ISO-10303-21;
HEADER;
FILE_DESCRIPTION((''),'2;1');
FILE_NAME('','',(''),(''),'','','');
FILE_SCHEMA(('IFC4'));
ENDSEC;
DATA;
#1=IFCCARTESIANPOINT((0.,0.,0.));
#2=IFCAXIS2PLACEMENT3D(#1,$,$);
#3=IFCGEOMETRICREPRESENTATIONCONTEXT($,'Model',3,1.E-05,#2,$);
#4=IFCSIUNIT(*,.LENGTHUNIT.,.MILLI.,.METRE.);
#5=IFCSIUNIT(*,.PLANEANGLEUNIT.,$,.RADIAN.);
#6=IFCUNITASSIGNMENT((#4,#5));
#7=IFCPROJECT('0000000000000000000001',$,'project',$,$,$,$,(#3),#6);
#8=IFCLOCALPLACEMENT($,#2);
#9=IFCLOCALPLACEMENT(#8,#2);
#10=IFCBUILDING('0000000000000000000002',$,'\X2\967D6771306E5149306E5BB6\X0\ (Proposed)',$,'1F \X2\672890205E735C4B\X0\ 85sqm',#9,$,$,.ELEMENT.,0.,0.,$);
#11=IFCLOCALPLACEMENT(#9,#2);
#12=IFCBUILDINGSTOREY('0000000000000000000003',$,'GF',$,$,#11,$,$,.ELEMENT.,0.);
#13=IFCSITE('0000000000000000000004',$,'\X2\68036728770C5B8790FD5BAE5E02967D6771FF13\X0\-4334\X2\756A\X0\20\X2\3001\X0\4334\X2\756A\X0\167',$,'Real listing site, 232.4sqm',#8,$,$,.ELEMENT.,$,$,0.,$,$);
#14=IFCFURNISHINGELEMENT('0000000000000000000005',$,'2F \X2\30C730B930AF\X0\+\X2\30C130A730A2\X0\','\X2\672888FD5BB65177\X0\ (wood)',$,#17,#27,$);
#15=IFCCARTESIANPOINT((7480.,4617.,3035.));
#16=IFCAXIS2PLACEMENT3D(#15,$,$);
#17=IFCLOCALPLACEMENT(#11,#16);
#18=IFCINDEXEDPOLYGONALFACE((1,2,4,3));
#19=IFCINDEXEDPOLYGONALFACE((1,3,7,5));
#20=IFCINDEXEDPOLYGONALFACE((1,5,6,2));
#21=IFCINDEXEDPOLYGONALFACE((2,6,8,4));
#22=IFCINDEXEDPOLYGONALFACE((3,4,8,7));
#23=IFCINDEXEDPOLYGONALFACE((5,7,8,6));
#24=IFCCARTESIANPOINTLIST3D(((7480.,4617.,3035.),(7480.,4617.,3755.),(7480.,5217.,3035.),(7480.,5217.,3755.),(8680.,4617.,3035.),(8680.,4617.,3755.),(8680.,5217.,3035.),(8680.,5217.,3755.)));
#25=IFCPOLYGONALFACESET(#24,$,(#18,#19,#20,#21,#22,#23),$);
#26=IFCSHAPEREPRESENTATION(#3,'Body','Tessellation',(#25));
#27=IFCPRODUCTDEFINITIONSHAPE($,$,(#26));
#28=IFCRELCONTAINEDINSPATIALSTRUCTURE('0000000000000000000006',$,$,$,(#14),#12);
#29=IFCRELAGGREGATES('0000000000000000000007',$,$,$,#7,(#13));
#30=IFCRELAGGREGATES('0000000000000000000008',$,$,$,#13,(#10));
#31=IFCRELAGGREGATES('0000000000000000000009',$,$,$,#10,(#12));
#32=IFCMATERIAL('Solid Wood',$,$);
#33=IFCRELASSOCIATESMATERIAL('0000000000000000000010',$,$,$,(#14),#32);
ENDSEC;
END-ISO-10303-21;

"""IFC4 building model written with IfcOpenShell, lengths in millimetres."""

from ifc_helpers import new_model, si_unit, frame, frame_2d, origin, place, context, project, spatial, rectangle, extrude, material, element, save


model = new_model("IFC4")

# Units and contexts
model_context = context("Model", 3, precision=1e-05, world=origin())
ifc_project = project(units=[si_unit("LENGTHUNIT", "METRE", prefix="MILLI"), si_unit("PLANEANGLEUNIT", "RADIAN")], contexts=[model_context])

# Site, building, storey
site_placement = place(None, origin())
site = spatial("IfcSite", under=ifc_project, at=site_placement, Name="栃木県宇都宮市陽東３-4334番20、4334番167", ObjectType="Real listing site, 232.4sqm", CompositionType="ELEMENT", RefElevation=0.0)
building_placement = place(site_placement, origin())
building = spatial("IfcBuilding", under=site, at=building_placement, Name="陽東の光の家 (Proposed)", ObjectType="1F 木造平屋 85sqm", CompositionType="ELEMENT", ElevationOfRefHeight=0.0, ElevationOfTerrain=0.0)
storey_placement = place(building_placement, origin())
storey = spatial("IfcBuildingStorey", under=building, at=storey_placement, Name="GF", CompositionType="ELEMENT", Elevation=0.0)

# Shared definitions
ifc_material_1 = material(Name="Solid Wood")

# Furnishing element
furnishing_1_placement = place(storey_placement, frame((7480.0, 4617.0, 3035.0)))
element("IfcFurnishingElement", 1, at=furnishing_1_placement, inside=storey, material=ifc_material_1, Name="2F デスク+チェア", Description="木製家具 (wood)", context=model_context, shape_type="SweptSolid", body=[
    extrude(rectangle(XDim=1200.0, YDim=600.0, at=frame_2d((600.0, 300.0))), frame((7480.0, 4617.0, 3035.0)), (0.0, 0.0, 1.0), 720.0),
])

save(model, "model.ifc")
